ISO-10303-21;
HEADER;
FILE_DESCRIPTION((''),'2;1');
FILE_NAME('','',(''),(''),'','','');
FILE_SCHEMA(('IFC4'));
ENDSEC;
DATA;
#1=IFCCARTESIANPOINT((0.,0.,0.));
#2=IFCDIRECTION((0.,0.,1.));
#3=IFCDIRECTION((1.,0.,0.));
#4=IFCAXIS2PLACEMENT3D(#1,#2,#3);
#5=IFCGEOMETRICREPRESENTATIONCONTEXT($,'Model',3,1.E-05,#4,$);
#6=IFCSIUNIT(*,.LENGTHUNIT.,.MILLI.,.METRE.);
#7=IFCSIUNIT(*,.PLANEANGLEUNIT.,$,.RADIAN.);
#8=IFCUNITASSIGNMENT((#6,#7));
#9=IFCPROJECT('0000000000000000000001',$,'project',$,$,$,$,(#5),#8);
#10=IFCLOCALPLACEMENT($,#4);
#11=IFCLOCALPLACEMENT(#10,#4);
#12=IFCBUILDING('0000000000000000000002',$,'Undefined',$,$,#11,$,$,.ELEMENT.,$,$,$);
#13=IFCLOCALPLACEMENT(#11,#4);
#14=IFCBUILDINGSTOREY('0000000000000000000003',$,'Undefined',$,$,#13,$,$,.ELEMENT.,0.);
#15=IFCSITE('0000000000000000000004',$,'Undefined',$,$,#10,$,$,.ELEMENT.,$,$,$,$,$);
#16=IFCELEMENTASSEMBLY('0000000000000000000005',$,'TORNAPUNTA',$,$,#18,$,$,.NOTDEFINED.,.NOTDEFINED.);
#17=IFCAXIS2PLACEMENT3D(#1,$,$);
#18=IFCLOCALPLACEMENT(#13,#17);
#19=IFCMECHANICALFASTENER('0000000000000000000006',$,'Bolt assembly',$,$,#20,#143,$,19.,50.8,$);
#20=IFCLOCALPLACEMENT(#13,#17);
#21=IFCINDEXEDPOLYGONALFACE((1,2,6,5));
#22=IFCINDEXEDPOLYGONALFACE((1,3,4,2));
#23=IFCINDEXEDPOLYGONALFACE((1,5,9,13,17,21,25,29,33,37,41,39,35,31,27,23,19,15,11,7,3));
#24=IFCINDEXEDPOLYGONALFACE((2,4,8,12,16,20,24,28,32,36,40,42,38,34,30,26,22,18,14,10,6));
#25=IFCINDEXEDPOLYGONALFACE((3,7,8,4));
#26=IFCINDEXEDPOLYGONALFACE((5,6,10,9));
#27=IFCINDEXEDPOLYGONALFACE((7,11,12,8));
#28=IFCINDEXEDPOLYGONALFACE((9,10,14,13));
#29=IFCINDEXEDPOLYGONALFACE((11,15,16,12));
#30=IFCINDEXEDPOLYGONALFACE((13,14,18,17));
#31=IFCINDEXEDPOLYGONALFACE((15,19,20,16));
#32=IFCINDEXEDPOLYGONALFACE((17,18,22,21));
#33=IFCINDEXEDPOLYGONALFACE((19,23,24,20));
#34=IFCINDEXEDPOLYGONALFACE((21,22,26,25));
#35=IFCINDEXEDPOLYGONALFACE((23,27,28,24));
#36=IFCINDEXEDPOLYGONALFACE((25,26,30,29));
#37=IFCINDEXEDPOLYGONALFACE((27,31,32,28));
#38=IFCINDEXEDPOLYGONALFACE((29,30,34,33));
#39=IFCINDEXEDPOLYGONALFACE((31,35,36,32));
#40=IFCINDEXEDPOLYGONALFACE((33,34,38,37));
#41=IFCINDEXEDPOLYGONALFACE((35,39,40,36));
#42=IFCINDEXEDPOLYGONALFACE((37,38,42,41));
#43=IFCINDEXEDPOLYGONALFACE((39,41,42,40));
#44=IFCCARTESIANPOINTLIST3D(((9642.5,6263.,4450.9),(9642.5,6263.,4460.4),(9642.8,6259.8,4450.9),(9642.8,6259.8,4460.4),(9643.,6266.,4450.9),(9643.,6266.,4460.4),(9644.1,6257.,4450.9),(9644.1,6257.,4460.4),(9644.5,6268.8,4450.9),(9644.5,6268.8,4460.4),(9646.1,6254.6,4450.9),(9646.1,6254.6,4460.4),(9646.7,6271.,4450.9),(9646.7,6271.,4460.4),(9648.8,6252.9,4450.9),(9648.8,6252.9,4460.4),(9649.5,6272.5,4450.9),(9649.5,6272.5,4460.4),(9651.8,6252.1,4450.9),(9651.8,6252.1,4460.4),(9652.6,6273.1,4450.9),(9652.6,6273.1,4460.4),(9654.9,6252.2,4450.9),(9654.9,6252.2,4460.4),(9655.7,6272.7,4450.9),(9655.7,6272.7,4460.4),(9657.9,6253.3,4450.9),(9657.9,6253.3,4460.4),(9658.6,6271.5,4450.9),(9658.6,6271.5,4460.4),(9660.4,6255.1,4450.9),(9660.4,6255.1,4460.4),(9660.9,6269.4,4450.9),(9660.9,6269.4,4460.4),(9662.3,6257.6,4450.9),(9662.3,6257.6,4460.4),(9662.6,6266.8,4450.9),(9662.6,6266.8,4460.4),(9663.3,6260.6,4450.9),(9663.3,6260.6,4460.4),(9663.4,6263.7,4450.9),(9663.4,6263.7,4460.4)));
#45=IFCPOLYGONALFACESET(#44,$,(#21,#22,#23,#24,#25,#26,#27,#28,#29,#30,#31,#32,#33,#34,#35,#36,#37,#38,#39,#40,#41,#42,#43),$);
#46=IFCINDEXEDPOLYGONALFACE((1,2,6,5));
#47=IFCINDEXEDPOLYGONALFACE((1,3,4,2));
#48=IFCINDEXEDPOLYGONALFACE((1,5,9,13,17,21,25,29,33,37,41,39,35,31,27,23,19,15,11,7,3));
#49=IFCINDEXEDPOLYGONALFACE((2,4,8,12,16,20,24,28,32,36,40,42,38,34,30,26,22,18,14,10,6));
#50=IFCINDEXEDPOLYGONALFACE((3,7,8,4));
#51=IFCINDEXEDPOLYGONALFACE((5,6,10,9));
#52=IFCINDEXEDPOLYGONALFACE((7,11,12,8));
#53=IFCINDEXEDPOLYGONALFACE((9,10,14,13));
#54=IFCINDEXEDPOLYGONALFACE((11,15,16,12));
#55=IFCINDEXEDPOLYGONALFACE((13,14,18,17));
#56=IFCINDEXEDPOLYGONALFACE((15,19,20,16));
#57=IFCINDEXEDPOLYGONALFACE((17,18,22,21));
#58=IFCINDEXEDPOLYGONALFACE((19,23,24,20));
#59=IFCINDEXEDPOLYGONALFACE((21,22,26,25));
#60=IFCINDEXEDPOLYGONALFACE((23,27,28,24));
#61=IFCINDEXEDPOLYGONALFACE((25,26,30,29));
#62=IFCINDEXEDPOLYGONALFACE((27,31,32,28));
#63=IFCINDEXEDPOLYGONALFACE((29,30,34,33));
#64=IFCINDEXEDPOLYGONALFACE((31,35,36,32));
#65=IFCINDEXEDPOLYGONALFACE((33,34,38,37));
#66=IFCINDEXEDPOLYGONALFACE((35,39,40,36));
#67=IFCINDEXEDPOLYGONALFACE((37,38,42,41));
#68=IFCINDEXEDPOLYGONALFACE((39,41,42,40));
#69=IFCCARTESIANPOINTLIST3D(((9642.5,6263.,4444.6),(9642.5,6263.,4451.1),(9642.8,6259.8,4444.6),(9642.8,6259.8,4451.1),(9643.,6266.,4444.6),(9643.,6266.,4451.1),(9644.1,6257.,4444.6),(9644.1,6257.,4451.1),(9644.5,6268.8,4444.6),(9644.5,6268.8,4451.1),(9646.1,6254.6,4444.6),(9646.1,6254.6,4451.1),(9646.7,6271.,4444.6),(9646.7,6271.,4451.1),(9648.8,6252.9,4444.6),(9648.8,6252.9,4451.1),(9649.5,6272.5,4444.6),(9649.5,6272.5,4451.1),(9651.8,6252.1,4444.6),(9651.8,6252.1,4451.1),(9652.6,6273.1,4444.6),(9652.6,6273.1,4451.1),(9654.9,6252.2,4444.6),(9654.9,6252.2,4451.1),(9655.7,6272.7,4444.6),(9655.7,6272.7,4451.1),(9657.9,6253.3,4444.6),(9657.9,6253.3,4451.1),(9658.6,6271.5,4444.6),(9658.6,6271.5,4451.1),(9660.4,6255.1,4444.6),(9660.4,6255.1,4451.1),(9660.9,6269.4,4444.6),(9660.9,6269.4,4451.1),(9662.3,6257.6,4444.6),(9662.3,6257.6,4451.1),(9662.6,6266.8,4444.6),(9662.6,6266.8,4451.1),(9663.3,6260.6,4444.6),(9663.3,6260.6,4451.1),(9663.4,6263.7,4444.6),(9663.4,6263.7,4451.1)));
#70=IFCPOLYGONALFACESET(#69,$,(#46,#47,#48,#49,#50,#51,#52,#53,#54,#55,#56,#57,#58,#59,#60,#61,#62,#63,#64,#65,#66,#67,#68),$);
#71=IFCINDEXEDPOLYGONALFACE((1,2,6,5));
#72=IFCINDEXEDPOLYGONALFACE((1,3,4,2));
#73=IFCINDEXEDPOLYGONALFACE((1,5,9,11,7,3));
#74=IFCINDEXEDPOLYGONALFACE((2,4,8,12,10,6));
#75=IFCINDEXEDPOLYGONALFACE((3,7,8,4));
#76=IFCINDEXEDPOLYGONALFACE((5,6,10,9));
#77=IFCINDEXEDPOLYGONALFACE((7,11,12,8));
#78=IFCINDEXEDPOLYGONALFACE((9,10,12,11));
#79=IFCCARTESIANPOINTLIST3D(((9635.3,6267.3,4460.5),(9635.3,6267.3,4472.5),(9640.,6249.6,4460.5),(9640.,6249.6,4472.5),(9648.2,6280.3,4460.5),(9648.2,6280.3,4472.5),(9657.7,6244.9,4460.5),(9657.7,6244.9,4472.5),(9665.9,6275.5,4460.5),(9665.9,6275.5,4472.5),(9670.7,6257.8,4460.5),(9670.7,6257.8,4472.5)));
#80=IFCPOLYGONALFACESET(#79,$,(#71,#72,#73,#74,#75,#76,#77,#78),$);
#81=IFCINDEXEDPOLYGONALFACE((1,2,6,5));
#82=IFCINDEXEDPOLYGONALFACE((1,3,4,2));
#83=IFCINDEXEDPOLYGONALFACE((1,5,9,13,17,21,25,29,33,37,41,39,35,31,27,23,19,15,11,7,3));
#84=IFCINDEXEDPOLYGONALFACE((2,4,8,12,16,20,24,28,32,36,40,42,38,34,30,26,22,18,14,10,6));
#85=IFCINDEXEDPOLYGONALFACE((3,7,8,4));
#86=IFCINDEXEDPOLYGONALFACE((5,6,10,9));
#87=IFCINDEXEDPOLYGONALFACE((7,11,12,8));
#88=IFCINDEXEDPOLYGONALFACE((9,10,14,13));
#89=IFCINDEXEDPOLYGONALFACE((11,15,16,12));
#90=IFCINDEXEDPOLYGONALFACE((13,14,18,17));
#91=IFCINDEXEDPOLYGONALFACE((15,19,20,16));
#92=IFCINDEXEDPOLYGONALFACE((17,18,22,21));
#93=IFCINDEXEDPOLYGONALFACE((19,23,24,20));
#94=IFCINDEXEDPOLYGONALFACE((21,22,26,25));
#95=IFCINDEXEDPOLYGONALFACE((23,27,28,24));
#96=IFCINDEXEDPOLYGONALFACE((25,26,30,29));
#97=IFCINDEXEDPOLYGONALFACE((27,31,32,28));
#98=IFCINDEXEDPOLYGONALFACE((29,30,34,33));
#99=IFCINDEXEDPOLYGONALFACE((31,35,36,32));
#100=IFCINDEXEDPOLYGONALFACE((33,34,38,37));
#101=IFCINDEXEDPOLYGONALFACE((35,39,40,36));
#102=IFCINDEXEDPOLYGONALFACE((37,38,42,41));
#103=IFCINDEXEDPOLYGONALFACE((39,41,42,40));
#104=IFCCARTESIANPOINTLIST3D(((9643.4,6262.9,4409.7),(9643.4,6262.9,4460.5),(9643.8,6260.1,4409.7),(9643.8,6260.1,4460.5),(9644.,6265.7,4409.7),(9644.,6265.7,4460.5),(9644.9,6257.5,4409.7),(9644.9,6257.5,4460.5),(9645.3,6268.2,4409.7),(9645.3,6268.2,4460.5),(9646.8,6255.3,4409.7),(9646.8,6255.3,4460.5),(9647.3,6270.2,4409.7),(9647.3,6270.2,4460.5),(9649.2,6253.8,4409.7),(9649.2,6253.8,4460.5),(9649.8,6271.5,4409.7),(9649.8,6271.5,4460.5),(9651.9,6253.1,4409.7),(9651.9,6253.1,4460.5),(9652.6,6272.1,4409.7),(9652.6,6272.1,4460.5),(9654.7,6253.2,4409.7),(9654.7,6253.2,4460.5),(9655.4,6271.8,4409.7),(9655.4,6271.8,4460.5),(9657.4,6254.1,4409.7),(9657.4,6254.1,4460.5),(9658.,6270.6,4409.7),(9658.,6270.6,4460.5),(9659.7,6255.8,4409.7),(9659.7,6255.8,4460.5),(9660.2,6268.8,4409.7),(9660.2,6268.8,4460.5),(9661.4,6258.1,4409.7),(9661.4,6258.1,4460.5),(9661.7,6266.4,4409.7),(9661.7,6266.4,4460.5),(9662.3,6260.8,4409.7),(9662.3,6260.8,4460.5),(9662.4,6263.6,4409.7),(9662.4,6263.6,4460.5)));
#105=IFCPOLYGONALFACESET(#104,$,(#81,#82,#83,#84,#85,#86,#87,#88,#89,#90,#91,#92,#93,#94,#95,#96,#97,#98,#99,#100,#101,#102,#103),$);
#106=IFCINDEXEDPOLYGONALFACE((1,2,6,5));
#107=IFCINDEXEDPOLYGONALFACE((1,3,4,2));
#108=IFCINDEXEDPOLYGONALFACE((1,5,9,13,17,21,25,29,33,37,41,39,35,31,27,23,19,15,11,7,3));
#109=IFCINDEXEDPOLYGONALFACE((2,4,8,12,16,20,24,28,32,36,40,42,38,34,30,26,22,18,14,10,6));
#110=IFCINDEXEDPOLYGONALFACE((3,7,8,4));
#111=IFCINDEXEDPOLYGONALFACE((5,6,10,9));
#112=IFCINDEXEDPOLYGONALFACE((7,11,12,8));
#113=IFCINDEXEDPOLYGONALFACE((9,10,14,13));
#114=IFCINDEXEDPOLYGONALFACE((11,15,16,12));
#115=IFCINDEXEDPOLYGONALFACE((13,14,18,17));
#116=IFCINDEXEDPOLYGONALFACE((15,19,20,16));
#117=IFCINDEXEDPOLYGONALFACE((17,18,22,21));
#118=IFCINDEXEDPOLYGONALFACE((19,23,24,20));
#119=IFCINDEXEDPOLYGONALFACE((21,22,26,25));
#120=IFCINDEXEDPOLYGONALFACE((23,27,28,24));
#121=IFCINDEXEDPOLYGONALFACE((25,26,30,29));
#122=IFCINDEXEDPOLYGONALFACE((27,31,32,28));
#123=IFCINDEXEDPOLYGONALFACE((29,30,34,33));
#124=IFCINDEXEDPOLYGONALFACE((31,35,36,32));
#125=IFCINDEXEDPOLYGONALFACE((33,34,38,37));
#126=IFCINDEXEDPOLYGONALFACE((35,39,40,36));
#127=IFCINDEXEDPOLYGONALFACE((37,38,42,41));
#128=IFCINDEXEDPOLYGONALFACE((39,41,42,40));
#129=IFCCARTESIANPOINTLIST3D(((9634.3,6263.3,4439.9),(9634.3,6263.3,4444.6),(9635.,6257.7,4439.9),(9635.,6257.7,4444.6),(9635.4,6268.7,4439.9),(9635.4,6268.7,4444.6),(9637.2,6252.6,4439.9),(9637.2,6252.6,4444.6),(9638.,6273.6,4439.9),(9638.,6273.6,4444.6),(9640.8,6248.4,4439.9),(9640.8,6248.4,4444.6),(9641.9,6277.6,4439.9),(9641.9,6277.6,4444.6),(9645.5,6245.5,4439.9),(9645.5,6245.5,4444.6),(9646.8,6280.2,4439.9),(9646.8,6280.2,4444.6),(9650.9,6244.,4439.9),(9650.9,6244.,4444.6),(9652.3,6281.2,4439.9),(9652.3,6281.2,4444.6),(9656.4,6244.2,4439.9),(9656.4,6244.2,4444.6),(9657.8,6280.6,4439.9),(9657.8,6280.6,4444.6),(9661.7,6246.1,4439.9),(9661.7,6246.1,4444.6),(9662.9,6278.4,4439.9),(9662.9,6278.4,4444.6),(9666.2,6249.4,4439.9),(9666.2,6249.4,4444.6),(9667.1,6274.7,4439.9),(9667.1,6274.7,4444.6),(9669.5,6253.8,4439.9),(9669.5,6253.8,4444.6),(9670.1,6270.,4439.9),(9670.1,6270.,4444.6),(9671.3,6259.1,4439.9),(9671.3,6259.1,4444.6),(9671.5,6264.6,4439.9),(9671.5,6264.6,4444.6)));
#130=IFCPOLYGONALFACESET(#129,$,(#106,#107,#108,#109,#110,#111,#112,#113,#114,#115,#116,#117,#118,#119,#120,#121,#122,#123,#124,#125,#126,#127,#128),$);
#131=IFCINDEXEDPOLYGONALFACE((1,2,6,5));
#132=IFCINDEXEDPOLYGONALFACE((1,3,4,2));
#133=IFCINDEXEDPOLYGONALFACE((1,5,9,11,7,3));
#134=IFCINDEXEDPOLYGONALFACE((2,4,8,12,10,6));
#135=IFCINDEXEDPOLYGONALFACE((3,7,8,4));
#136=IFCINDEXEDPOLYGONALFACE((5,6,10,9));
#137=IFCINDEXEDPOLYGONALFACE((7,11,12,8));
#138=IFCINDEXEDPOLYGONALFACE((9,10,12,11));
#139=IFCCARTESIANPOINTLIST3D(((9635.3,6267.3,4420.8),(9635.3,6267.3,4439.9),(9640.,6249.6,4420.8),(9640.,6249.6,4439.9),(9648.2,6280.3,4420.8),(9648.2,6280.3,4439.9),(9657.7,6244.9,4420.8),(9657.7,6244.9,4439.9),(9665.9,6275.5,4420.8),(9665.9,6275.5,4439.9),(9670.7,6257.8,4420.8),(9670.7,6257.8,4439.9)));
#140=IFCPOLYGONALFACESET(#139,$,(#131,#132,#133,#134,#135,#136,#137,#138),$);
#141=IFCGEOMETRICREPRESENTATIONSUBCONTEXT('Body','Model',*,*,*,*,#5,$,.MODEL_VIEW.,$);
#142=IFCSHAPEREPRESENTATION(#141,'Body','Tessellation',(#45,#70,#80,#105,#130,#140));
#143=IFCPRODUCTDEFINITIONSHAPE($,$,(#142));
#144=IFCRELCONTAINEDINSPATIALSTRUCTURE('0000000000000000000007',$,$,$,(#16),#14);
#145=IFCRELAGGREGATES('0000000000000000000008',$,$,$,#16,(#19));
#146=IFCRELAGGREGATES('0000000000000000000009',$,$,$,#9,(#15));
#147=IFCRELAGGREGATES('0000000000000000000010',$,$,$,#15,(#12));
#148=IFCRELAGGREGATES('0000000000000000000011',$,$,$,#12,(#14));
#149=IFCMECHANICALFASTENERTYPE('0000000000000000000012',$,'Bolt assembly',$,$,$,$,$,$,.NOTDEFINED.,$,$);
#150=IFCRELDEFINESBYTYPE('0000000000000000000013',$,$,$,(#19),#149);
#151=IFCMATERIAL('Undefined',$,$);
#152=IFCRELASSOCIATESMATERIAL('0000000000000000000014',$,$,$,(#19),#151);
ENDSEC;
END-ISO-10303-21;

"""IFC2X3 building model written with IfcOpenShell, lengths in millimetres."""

from ifc_helpers import new_model, si_unit, frame, origin_with_axes, origin_2d_with_axis, place, context, subcontext, project, spatial, polyline, circle, outline, extrude, source, transform, mapped, material, type_object, element, aggregate, save


model = new_model("IFC2X3")

# Units and contexts
model_context = context("Model", 3, precision=1e-05, world=origin_with_axes())
body_context = subcontext(model_context, "Body", "Model", "MODEL_VIEW")
ifc_project = project(units=[si_unit("LENGTHUNIT", "METRE", prefix="MILLI"), si_unit("PLANEANGLEUNIT", "RADIAN")], contexts=[model_context])

# Site, building, storey
site_placement = place(None, origin_with_axes())
site = spatial("IfcSite", under=ifc_project, at=site_placement, Name="Undefined", CompositionType="ELEMENT")
building_placement = place(site_placement, origin_with_axes())
building = spatial("IfcBuilding", under=site, at=building_placement, Name="Undefined", CompositionType="ELEMENT")
storey_placement = place(building_placement, origin_with_axes())
storey = spatial("IfcBuildingStorey", under=building, at=storey_placement, Name="Undefined", CompositionType="ELEMENT", Elevation=0.0)

# Shared definitions
ifc_material_1 = material(Name="Undefined")
mechanical_fastener_type = type_object("IfcMechanicalFastenerType", Name="Bolt assembly")

# Element assembly, mechanical fastener
assembly_1_placement = place(storey_placement, origin_with_axes())
assembly_1 = element("IfcElementAssembly", 1, at=assembly_1_placement, inside=storey, Name="TORNAPUNTA", AssemblyPlace="NOTDEFINED", PredefinedType="NOTDEFINED")
shared_shape_1 = source(origin_with_axes(), body_context, "Body", "SweptSolid", [
    extrude(circle(Radius=10.5, at=origin_2d_with_axis()), frame((0.0, -9.4, 0.0), z_axis=(0.0, 1.0, 0.0), x_axis=(1.0, 0.0, 0.0)), (0.0, 0.0, 1.0), 9.5),
    extrude(circle(Radius=10.5, at=origin_2d_with_axis()), frame((0.0, -0.1, 0.0), z_axis=(0.0, 1.0, 0.0), x_axis=(1.0, 0.0, 0.0)), (0.0, 0.0, 1.0), 6.5),
    extrude(outline(polyline([(15.9, -9.2), (15.9, 9.2), (0.0, 18.3), (-15.9, 9.2), (-15.9, -9.2), (0.0, -18.3), (15.9, -9.2)])), frame((0.0, -21.4, 0.0), z_axis=(0.0, 1.0, 0.0), x_axis=(1.0, 0.0, 0.0)), (0.0, 0.0, 1.0), 11.9),
    extrude(circle(Radius=9.5, at=origin_2d_with_axis()), frame((0.0, -9.5, 0.0), z_axis=(0.0, 1.0, 0.0), x_axis=(1.0, 0.0, 0.0)), (0.0, 0.0, 1.0), 50.8),
    extrude(circle(Radius=18.7, at=origin_2d_with_axis()), frame((0.0, 6.4, 0.0), z_axis=(0.0, 1.0, 0.0), x_axis=(1.0, 0.0, 0.0)), (0.0, 0.0, 1.0), 4.8),
    extrude(outline(polyline([(15.9, -9.2), (15.9, 9.2), (0.0, 18.3), (-15.9, 9.2), (-15.9, -9.2), (0.0, -18.3), (15.9, -9.2)])), frame((0.0, 11.2, 0.0), z_axis=(0.0, 1.0, 0.0), x_axis=(1.0, 0.0, 0.0)), (0.0, 0.0, 1.0), 19.1),
])
mechanical_fastener_1_placement = place(assembly_1_placement, frame((9653.0, 6262.6, 4451.0), z_axis=(0.707107, 0.707107, 0.0), x_axis=(0.707107, -0.707107, 0.0)))
mechanical_fastener_1 = element("IfcMechanicalFastener", 2, at=mechanical_fastener_1_placement, type_object=mechanical_fastener_type, material=ifc_material_1, Name="Bolt assembly", NominalDiameter=19.0, NominalLength=50.8, context=body_context, shape_type="MappedRepresentation", body=[
    mapped(shared_shape_1, transform((0.0, 0.0, 0.0))),
])
aggregate(assembly_1, [mechanical_fastener_1])

save(model, "model.ifc")
